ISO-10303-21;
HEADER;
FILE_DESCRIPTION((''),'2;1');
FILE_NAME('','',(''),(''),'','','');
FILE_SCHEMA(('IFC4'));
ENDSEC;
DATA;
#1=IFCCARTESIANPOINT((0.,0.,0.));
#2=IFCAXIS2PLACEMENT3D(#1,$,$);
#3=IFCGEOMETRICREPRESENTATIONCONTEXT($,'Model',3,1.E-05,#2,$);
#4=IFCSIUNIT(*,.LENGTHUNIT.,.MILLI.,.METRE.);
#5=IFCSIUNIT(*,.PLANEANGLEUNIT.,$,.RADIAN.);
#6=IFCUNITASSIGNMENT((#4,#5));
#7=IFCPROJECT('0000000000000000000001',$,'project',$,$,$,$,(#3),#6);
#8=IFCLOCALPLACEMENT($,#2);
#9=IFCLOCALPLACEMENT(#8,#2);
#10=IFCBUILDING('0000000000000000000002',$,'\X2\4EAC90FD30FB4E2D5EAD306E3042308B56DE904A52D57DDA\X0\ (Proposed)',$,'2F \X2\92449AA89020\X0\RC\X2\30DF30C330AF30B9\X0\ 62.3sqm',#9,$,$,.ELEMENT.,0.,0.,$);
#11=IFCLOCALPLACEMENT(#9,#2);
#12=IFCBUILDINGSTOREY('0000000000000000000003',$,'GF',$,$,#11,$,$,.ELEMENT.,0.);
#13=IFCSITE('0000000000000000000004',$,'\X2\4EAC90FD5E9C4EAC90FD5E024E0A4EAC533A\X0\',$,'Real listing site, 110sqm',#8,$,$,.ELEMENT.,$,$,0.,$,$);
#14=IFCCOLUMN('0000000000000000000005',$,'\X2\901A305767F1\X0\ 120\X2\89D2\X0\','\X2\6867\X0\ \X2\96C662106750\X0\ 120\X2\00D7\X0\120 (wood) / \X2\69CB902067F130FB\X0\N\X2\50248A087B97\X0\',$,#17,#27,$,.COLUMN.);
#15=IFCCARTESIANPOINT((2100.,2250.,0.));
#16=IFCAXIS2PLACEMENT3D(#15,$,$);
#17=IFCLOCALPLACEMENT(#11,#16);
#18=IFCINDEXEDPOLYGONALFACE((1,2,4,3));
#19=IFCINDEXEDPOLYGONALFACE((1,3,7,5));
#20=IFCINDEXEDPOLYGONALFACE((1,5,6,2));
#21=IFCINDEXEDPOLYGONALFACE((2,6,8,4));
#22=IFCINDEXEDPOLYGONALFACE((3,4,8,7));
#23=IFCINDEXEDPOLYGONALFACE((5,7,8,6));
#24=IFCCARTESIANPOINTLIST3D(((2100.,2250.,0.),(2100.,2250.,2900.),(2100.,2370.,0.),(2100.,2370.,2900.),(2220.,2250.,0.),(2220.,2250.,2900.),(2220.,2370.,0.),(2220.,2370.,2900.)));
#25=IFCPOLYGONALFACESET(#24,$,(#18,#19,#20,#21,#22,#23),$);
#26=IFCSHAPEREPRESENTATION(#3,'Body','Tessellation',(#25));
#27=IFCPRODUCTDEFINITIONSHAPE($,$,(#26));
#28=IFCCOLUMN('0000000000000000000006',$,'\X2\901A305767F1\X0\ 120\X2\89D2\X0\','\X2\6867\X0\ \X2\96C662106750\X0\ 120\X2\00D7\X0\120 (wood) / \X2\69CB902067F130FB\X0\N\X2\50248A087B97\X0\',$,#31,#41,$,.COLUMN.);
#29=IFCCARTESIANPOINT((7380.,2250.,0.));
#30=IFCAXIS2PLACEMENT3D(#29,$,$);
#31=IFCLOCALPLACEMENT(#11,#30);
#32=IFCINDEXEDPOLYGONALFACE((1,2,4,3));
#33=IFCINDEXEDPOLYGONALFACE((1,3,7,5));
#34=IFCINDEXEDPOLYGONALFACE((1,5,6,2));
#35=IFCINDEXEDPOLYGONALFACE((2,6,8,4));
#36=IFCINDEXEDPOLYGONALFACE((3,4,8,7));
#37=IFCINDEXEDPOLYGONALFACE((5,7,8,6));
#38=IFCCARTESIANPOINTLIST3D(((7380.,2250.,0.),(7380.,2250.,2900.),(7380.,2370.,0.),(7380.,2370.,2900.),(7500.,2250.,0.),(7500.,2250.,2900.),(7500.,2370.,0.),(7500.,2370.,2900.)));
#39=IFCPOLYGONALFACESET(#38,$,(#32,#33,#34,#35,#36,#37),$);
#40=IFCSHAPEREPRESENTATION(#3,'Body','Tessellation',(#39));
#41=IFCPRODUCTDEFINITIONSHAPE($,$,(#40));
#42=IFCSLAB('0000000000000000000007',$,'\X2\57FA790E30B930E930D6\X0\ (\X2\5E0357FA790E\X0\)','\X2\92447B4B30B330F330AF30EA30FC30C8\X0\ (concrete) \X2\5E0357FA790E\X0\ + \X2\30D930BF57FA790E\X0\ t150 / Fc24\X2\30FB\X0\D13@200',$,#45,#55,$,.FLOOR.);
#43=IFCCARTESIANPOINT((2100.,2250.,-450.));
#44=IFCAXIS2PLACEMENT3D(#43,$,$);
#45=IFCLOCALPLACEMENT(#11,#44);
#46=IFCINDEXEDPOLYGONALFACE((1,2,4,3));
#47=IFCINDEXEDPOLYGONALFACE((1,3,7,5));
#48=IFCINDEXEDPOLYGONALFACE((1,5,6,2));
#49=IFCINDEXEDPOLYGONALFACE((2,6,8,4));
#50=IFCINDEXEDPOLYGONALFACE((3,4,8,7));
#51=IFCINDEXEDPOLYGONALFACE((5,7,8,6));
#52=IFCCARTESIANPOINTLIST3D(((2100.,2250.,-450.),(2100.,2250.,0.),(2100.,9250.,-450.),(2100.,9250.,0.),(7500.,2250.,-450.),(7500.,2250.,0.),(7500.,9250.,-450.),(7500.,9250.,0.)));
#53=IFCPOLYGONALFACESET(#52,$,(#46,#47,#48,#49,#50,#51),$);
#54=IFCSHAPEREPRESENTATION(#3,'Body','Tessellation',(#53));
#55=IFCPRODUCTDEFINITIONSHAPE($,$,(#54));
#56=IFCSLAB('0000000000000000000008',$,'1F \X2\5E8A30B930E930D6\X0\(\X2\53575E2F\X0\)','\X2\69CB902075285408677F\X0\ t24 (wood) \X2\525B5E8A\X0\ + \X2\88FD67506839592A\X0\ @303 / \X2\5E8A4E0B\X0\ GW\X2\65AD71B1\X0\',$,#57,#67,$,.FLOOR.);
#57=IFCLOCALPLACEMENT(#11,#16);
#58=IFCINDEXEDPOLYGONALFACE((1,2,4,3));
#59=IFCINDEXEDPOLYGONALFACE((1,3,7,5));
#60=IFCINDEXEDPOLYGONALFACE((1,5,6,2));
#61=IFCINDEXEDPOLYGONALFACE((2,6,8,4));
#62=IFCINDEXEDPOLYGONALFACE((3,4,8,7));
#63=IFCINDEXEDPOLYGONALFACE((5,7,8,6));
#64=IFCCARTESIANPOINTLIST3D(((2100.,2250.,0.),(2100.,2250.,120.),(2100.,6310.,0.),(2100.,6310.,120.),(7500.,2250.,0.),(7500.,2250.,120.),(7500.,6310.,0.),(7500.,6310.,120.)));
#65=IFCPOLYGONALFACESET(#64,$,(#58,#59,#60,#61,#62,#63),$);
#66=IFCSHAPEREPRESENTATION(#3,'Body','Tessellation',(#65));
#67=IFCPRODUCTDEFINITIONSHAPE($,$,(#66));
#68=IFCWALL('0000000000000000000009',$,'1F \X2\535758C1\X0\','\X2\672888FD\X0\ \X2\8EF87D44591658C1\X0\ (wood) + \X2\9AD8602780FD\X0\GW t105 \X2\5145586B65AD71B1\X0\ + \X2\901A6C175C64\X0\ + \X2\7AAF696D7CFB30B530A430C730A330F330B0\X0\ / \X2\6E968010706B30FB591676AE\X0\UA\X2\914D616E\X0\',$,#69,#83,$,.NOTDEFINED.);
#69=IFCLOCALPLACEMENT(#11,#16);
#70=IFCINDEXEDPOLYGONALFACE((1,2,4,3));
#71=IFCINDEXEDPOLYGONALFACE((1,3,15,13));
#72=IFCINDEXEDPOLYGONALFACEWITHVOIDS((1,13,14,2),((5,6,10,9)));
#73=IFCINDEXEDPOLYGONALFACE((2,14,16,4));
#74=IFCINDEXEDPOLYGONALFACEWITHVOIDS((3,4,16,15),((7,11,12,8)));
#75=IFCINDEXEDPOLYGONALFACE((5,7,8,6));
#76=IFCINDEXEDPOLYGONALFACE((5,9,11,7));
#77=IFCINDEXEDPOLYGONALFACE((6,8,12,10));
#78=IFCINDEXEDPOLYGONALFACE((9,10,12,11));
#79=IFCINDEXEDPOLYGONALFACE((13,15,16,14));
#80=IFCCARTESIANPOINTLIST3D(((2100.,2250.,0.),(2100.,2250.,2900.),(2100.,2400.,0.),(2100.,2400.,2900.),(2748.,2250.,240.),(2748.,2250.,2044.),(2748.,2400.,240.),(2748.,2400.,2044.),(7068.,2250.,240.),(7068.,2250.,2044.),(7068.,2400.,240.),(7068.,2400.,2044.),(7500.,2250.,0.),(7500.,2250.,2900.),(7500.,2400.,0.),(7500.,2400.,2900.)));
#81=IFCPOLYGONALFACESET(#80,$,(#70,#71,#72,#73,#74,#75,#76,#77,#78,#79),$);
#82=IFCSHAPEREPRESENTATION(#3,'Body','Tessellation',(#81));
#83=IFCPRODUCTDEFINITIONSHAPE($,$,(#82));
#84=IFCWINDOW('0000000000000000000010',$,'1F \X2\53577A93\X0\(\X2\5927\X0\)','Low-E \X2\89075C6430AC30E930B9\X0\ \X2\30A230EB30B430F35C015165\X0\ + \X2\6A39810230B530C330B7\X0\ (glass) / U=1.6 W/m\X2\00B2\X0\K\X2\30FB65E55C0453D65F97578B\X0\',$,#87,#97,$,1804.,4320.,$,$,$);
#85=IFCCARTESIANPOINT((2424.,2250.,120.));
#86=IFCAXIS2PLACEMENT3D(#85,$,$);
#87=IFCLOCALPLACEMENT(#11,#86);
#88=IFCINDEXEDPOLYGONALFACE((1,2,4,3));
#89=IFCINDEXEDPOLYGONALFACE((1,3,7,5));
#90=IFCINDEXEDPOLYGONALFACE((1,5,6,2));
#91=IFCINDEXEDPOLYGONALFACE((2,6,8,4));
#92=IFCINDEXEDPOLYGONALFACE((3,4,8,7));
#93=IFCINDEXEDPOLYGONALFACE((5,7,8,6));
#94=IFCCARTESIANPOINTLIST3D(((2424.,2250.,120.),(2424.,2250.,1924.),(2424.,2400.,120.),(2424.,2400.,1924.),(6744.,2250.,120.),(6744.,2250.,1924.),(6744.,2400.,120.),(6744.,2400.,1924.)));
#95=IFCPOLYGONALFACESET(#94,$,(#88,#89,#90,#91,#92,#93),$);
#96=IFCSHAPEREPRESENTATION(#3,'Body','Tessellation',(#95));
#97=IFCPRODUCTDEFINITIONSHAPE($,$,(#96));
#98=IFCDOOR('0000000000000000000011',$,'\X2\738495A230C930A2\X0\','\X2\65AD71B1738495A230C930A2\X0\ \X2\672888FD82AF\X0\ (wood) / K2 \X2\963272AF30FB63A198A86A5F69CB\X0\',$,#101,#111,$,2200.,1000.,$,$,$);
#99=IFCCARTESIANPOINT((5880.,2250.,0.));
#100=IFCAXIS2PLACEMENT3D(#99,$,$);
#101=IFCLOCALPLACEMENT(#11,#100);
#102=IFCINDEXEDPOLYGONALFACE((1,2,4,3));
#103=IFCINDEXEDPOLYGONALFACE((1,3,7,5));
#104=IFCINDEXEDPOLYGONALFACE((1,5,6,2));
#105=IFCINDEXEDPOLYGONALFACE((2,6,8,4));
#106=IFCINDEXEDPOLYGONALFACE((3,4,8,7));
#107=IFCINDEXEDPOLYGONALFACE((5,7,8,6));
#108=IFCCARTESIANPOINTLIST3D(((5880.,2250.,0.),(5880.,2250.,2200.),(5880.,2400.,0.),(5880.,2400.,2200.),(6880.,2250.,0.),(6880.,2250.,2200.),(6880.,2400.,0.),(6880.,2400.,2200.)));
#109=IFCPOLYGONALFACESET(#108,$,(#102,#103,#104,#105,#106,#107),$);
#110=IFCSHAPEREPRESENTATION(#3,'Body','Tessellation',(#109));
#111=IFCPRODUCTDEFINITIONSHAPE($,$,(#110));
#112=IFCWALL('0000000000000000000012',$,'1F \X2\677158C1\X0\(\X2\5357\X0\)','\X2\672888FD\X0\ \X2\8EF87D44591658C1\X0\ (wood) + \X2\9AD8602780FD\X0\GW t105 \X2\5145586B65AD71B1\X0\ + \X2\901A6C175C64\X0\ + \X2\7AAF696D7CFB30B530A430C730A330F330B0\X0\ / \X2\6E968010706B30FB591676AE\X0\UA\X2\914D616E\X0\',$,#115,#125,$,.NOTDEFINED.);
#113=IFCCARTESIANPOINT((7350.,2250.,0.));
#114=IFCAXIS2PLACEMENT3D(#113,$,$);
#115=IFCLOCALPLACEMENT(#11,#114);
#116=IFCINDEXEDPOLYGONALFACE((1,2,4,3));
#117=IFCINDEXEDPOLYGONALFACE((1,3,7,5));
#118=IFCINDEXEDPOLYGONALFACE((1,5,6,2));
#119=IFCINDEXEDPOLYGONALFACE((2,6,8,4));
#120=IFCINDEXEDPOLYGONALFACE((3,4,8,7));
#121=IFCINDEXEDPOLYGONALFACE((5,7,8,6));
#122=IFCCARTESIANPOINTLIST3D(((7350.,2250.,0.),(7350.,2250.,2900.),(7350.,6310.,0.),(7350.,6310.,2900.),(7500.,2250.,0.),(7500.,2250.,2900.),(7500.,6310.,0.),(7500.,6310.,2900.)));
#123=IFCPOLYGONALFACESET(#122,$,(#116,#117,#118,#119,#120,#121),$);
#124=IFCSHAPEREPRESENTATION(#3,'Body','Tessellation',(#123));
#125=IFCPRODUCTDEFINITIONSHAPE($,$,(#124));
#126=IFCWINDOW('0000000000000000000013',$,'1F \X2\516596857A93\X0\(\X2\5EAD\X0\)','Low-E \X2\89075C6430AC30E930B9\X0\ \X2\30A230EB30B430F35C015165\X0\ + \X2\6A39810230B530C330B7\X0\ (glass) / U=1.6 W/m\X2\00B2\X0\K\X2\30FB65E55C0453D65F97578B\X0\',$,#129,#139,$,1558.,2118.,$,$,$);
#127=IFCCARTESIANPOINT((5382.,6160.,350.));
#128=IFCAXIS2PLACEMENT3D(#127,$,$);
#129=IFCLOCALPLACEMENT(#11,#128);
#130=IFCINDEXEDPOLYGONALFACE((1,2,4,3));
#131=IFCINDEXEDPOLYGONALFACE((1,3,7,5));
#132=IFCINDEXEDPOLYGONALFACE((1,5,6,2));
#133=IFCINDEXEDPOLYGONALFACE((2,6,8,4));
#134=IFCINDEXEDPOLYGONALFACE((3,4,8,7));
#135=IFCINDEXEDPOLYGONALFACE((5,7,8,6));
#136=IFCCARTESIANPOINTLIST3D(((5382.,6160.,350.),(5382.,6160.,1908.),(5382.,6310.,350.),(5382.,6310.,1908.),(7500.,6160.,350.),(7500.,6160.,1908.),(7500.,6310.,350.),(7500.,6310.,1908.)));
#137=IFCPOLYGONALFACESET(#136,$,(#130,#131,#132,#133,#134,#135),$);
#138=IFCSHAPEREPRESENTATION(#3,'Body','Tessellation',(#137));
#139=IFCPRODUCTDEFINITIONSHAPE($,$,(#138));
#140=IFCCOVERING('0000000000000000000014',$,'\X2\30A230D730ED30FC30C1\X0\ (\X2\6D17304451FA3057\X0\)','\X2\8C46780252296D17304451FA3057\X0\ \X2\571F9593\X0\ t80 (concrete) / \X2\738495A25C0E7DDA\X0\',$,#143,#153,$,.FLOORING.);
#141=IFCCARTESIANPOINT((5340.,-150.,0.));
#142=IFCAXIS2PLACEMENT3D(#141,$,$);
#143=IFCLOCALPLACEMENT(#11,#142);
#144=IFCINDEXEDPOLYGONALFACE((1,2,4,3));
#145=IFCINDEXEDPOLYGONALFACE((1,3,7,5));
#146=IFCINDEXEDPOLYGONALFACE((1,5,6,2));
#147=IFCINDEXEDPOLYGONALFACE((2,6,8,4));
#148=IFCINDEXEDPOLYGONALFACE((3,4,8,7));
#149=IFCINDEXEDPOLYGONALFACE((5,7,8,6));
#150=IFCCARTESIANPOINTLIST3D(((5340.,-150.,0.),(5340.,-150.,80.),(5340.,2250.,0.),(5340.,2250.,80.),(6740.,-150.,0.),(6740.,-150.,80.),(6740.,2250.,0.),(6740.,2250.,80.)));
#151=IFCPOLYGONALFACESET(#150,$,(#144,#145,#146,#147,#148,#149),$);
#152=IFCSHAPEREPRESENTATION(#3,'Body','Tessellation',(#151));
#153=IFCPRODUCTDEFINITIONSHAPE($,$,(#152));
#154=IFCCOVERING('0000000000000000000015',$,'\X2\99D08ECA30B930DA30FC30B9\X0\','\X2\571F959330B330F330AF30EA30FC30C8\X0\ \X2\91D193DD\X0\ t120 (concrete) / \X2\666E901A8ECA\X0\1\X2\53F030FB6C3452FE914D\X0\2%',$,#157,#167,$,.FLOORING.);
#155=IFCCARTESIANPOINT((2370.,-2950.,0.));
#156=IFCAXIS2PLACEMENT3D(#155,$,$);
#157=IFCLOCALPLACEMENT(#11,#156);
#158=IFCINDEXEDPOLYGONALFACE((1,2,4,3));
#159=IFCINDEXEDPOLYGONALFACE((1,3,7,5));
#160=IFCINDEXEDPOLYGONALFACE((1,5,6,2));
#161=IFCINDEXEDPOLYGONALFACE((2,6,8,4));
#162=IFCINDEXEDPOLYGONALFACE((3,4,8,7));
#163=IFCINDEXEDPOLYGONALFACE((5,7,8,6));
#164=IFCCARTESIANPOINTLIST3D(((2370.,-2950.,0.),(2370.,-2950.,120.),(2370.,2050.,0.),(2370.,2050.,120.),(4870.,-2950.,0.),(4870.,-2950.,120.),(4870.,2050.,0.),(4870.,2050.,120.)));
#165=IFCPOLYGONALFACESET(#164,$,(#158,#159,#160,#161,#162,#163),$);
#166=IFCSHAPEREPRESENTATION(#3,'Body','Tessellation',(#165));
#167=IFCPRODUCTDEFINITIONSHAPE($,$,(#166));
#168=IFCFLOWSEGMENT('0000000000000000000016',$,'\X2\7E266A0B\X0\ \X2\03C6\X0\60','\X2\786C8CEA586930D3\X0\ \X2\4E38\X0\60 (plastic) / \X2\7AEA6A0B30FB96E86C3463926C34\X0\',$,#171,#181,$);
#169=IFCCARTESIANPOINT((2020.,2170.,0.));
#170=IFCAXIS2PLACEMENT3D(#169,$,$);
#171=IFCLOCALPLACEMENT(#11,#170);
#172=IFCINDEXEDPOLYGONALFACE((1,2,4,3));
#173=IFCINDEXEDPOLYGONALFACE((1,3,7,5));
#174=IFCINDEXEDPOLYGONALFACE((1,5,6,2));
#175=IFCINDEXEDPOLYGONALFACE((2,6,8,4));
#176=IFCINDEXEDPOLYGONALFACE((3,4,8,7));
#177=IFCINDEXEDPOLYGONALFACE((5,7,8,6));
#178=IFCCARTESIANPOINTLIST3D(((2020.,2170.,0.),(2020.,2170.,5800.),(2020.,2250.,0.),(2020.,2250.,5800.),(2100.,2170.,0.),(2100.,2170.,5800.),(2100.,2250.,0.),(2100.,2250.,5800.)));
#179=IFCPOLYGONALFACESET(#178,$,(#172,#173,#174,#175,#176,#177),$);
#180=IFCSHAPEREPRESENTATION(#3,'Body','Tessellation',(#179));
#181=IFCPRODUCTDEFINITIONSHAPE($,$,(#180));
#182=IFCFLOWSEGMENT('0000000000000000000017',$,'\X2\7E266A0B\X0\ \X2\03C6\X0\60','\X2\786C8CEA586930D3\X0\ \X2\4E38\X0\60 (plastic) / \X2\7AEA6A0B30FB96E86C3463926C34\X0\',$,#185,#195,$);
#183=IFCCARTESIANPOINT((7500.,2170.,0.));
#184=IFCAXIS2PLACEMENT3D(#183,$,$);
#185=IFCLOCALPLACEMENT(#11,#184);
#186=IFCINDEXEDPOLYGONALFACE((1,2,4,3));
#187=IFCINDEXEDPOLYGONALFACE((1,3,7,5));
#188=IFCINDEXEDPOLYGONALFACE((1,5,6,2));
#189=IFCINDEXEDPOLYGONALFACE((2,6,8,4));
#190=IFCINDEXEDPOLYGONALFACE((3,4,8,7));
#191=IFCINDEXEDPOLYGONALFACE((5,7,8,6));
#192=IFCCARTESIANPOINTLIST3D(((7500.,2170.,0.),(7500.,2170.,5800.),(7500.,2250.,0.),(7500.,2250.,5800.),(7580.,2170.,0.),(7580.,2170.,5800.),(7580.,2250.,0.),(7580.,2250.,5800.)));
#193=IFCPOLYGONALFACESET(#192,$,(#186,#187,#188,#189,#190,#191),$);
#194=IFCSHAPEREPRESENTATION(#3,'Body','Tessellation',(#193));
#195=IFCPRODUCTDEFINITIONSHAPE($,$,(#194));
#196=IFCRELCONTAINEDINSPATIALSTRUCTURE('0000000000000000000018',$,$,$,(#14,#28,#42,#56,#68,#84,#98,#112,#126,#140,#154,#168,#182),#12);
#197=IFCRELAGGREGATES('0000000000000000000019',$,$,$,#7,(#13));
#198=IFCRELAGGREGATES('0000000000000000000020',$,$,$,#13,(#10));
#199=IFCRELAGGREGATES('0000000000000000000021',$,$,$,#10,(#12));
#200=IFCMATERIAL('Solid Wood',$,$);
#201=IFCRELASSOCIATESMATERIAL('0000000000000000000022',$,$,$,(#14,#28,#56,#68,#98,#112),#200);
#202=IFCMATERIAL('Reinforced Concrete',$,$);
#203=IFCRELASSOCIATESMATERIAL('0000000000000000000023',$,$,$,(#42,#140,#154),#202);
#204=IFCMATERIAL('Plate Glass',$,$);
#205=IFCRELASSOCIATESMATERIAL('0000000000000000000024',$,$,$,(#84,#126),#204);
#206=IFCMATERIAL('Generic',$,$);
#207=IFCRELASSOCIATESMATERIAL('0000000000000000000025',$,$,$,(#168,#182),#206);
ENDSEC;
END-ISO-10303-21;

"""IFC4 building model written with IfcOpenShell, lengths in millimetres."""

from ifc_helpers import new_model, si_unit, frame, frame_2d, origin, place, context, project, spatial, rectangle, extrude, material, element, fill, save


model = new_model("IFC4")

# Units and contexts
model_context = context("Model", 3, precision=1e-05, world=origin())
ifc_project = project(units=[si_unit("LENGTHUNIT", "METRE", prefix="MILLI"), si_unit("PLANEANGLEUNIT", "RADIAN")], contexts=[model_context])

# Site, building, storey
site_placement = place(None, origin())
site = spatial("IfcSite", under=ifc_project, at=site_placement, Name="京都府京都市上京区", ObjectType="Real listing site, 110sqm", CompositionType="ELEMENT", RefElevation=0.0)
building_placement = place(site_placement, origin())
building = spatial("IfcBuilding", under=site, at=building_placement, Name="京都・中庭のある回遊動線 (Proposed)", ObjectType="2F 鉄骨造RCミックス 62.3sqm", CompositionType="ELEMENT", ElevationOfRefHeight=0.0, ElevationOfTerrain=0.0)
storey_placement = place(building_placement, origin())
storey = spatial("IfcBuildingStorey", under=building, at=storey_placement, Name="GF", CompositionType="ELEMENT", Elevation=0.0)

# Columns
ifc_material_1 = material(Name="Solid Wood")
column_1_placement = place(storey_placement, frame((2100.0, 2250.0, 0.0)))
element("IfcColumn", 1, at=column_1_placement, inside=storey, material=ifc_material_1, Name="通し柱 120角", Description="桧 集成材 120×120 (wood) / 構造柱・N値計算", PredefinedType="COLUMN", context=model_context, shape_type="SweptSolid", body=[
    extrude(rectangle(XDim=120.0, YDim=120.0, at=frame_2d((60.0, 60.0))), frame((2100.0, 2250.0, 0.0)), (0.0, 0.0, 1.0), 2900.0),
])
column_2_placement = place(storey_placement, frame((7380.0, 2250.0, 0.0)))
element("IfcColumn", 2, at=column_2_placement, inside=storey, material=ifc_material_1, Name="通し柱 120角", Description="桧 集成材 120×120 (wood) / 構造柱・N値計算", PredefinedType="COLUMN", context=model_context, shape_type="SweptSolid", body=[
    extrude(rectangle(XDim=120.0, YDim=120.0, at=frame_2d((60.0, 60.0))), frame((7380.0, 2250.0, 0.0)), (0.0, 0.0, 1.0), 2900.0),
])

# Slabs
ifc_material_2 = material(Name="Reinforced Concrete")
slab_1_placement = place(storey_placement, frame((2100.0, 2250.0, -450.0)))
element("IfcSlab", 3, at=slab_1_placement, inside=storey, material=ifc_material_2, Name="基礎スラブ (布基礎)", Description="鉄筋コンクリート (concrete) 布基礎 + ベタ基礎 t150 / Fc24・D13@200", PredefinedType="FLOOR", context=model_context, shape_type="SweptSolid", body=[
    extrude(rectangle(XDim=5400.0, YDim=7000.0, at=frame_2d((2700.0, 3500.0))), frame((2100.0, 2250.0, -450.0)), (0.0, 0.0, 1.0), 450.0),
])
slab_2_placement = place(storey_placement, frame((2100.0, 2250.0, 0.0)))
element("IfcSlab", 4, at=slab_2_placement, inside=storey, material=ifc_material_1, Name="1F 床スラブ(南帯)", Description="構造用合板 t24 (wood) 剛床 + 製材根太 @303 / 床下 GW断熱", PredefinedType="FLOOR", context=model_context, shape_type="SweptSolid", body=[
    extrude(rectangle(XDim=5400.0, YDim=4060.0, at=frame_2d((2700.0, 2030.0))), frame((2100.0, 2250.0, 0.0)), (0.0, 0.0, 1.0), 120.0),
])

# Wall, openings, window, door
wall_1_placement = place(storey_placement, frame((2100.0, 2250.0, 0.0)))
wall_1 = element("IfcWall", 5, at=wall_1_placement, inside=storey, material=ifc_material_1, Name="1F 南壁", Description="木製 軸組外壁 (wood) + 高性能GW t105 充填断熱 + 通気層 + 窯業系サイディング / 準耐火・外皮UA配慮", PredefinedType="NOTDEFINED", context=model_context, shape_type="SweptSolid", body=[
    extrude(rectangle(XDim=5400.0, YDim=150.0, at=frame_2d((2700.0, 75.0))), frame((2100.0, 2250.0, 0.0)), (0.0, 0.0, 1.0), 2900.0),
])
opening_1_placement = place(storey_placement, frame((2424.0, 2250.0, 120.0)))
opening_1 = element("IfcOpeningElement", 6, at=opening_1_placement, cuts=wall_1, PredefinedType="NOTDEFINED", context=model_context, shape_type="SweptSolid", body=[
    extrude(rectangle(XDim=4320.0, YDim=150.0, at=frame_2d((2160.0, 75.0))), frame((2424.0, 2250.0, 120.0)), (0.0, 0.0, 1.0), 1804.0),
])
opening_2_placement = place(storey_placement, frame((5880.0, 2250.0, 0.0)))
opening_2 = element("IfcOpeningElement", 7, at=opening_2_placement, cuts=wall_1, PredefinedType="NOTDEFINED", context=model_context, shape_type="SweptSolid", body=[
    extrude(rectangle(XDim=1000.0, YDim=150.0, at=frame_2d((500.0, 75.0))), frame((5880.0, 2250.0, 0.0)), (0.0, 0.0, 1.0), 2200.0),
])
ifc_material_3 = material(Name="Plate Glass")
window_1_placement = place(storey_placement, frame((2424.0, 2250.0, 120.0)))
window_1 = element("IfcWindow", 8, at=window_1_placement, inside=storey, material=ifc_material_3, Name="1F 南窓(大)", Description="Low-E 複層ガラス アルゴン封入 + 樹脂サッシ (glass) / U=1.6 W/m²K・日射取得型", OverallHeight=1804.0, OverallWidth=4320.0, context=model_context, shape_type="SweptSolid", body=[
    extrude(rectangle(XDim=4320.0, YDim=150.0, at=frame_2d((2160.0, 75.0))), frame((2424.0, 2250.0, 120.0)), (0.0, 0.0, 1.0), 1804.0),
])
fill(opening_1, window_1)
door_1_placement = place(storey_placement, frame((5880.0, 2250.0, 0.0)))
door_1 = element("IfcDoor", 9, at=door_1_placement, inside=storey, material=ifc_material_1, Name="玄関ドア", Description="断熱玄関ドア 木製芯 (wood) / K2 防犯・採風機構", OverallHeight=2200.0, OverallWidth=1000.0, context=model_context, shape_type="SweptSolid", body=[
    extrude(rectangle(XDim=1000.0, YDim=150.0, at=frame_2d((500.0, 75.0))), frame((5880.0, 2250.0, 0.0)), (0.0, 0.0, 1.0), 2200.0),
])
fill(opening_2, door_1)

# Wall, opening, window
wall_2_placement = place(storey_placement, frame((7350.0, 2250.0, 0.0)))
wall_2 = element("IfcWall", 10, at=wall_2_placement, inside=storey, material=ifc_material_1, Name="1F 東壁(南)", Description="木製 軸組外壁 (wood) + 高性能GW t105 充填断熱 + 通気層 + 窯業系サイディング / 準耐火・外皮UA配慮", PredefinedType="NOTDEFINED", context=model_context, shape_type="SweptSolid", body=[
    extrude(rectangle(XDim=150.0, YDim=4060.0, at=frame_2d((75.0, 2030.0))), frame((7350.0, 2250.0, 0.0)), (0.0, 0.0, 1.0), 2900.0),
])
opening_3_placement = place(storey_placement, frame((5382.0, 6160.0, 350.0)))
opening_3 = element("IfcOpeningElement", 11, at=opening_3_placement, cuts=wall_2, PredefinedType="NOTDEFINED", context=model_context, shape_type="SweptSolid", body=[
    extrude(rectangle(XDim=2118.0, YDim=150.0, at=frame_2d((1059.0, 75.0))), frame((5382.0, 6160.0, 350.0)), (0.0, 0.0, 1.0), 1558.0),
])
window_2_placement = place(storey_placement, frame((5382.0, 6160.0, 350.0)))
window_2 = element("IfcWindow", 12, at=window_2_placement, inside=storey, material=ifc_material_3, Name="1F 入隅窓(庭)", Description="Low-E 複層ガラス アルゴン封入 + 樹脂サッシ (glass) / U=1.6 W/m²K・日射取得型", OverallHeight=1558.0, OverallWidth=2118.0, context=model_context, shape_type="SweptSolid", body=[
    extrude(rectangle(XDim=2118.0, YDim=150.0, at=frame_2d((1059.0, 75.0))), frame((5382.0, 6160.0, 350.0)), (0.0, 0.0, 1.0), 1558.0),
])
fill(opening_3, window_2)

# Coverings
covering_1_placement = place(storey_placement, frame((5340.0, -150.0, 0.0)))
element("IfcCovering", 13, at=covering_1_placement, inside=storey, material=ifc_material_2, Name="アプローチ (洗い出し)", Description="豆砂利洗い出し 土間 t80 (concrete) / 玄関導線", PredefinedType="FLOORING", context=model_context, shape_type="SweptSolid", body=[
    extrude(rectangle(XDim=1400.0, YDim=2400.0, at=frame_2d((700.0, 1200.0))), frame((5340.0, -150.0, 0.0)), (0.0, 0.0, 1.0), 80.0),
])
covering_2_placement = place(storey_placement, frame((2370.0, -2950.0, 0.0)))
element("IfcCovering", 14, at=covering_2_placement, inside=storey, material=ifc_material_2, Name="駐車スペース", Description="土間コンクリート 金鏝 t120 (concrete) / 普通車1台・水勾配2%", PredefinedType="FLOORING", context=model_context, shape_type="SweptSolid", body=[
    extrude(rectangle(XDim=2500.0, YDim=5000.0, at=frame_2d((1250.0, 2500.0))), frame((2370.0, -2950.0, 0.0)), (0.0, 0.0, 1.0), 120.0),
])

# Flow segments
ifc_material_4 = material(Name="Generic")
flow_segment_1_placement = place(storey_placement, frame((2020.0, 2170.0, 0.0)))
element("IfcFlowSegment", 15, at=flow_segment_1_placement, inside=storey, material=ifc_material_4, Name="縦樋 φ60", Description="硬質塩ビ 丸60 (plastic) / 竪樋・雨水排水", context=model_context, shape_type="SweptSolid", body=[
    extrude(rectangle(XDim=80.0, YDim=80.0, at=frame_2d((40.0, 40.0))), frame((2020.0, 2170.0, 0.0)), (0.0, 0.0, 1.0), 5800.0),
])
flow_segment_2_placement = place(storey_placement, frame((7500.0, 2170.0, 0.0)))
element("IfcFlowSegment", 16, at=flow_segment_2_placement, inside=storey, material=ifc_material_4, Name="縦樋 φ60", Description="硬質塩ビ 丸60 (plastic) / 竪樋・雨水排水", context=model_context, shape_type="SweptSolid", body=[
    extrude(rectangle(XDim=80.0, YDim=80.0, at=frame_2d((40.0, 40.0))), frame((7500.0, 2170.0, 0.0)), (0.0, 0.0, 1.0), 5800.0),
])

save(model, "model.ifc")
